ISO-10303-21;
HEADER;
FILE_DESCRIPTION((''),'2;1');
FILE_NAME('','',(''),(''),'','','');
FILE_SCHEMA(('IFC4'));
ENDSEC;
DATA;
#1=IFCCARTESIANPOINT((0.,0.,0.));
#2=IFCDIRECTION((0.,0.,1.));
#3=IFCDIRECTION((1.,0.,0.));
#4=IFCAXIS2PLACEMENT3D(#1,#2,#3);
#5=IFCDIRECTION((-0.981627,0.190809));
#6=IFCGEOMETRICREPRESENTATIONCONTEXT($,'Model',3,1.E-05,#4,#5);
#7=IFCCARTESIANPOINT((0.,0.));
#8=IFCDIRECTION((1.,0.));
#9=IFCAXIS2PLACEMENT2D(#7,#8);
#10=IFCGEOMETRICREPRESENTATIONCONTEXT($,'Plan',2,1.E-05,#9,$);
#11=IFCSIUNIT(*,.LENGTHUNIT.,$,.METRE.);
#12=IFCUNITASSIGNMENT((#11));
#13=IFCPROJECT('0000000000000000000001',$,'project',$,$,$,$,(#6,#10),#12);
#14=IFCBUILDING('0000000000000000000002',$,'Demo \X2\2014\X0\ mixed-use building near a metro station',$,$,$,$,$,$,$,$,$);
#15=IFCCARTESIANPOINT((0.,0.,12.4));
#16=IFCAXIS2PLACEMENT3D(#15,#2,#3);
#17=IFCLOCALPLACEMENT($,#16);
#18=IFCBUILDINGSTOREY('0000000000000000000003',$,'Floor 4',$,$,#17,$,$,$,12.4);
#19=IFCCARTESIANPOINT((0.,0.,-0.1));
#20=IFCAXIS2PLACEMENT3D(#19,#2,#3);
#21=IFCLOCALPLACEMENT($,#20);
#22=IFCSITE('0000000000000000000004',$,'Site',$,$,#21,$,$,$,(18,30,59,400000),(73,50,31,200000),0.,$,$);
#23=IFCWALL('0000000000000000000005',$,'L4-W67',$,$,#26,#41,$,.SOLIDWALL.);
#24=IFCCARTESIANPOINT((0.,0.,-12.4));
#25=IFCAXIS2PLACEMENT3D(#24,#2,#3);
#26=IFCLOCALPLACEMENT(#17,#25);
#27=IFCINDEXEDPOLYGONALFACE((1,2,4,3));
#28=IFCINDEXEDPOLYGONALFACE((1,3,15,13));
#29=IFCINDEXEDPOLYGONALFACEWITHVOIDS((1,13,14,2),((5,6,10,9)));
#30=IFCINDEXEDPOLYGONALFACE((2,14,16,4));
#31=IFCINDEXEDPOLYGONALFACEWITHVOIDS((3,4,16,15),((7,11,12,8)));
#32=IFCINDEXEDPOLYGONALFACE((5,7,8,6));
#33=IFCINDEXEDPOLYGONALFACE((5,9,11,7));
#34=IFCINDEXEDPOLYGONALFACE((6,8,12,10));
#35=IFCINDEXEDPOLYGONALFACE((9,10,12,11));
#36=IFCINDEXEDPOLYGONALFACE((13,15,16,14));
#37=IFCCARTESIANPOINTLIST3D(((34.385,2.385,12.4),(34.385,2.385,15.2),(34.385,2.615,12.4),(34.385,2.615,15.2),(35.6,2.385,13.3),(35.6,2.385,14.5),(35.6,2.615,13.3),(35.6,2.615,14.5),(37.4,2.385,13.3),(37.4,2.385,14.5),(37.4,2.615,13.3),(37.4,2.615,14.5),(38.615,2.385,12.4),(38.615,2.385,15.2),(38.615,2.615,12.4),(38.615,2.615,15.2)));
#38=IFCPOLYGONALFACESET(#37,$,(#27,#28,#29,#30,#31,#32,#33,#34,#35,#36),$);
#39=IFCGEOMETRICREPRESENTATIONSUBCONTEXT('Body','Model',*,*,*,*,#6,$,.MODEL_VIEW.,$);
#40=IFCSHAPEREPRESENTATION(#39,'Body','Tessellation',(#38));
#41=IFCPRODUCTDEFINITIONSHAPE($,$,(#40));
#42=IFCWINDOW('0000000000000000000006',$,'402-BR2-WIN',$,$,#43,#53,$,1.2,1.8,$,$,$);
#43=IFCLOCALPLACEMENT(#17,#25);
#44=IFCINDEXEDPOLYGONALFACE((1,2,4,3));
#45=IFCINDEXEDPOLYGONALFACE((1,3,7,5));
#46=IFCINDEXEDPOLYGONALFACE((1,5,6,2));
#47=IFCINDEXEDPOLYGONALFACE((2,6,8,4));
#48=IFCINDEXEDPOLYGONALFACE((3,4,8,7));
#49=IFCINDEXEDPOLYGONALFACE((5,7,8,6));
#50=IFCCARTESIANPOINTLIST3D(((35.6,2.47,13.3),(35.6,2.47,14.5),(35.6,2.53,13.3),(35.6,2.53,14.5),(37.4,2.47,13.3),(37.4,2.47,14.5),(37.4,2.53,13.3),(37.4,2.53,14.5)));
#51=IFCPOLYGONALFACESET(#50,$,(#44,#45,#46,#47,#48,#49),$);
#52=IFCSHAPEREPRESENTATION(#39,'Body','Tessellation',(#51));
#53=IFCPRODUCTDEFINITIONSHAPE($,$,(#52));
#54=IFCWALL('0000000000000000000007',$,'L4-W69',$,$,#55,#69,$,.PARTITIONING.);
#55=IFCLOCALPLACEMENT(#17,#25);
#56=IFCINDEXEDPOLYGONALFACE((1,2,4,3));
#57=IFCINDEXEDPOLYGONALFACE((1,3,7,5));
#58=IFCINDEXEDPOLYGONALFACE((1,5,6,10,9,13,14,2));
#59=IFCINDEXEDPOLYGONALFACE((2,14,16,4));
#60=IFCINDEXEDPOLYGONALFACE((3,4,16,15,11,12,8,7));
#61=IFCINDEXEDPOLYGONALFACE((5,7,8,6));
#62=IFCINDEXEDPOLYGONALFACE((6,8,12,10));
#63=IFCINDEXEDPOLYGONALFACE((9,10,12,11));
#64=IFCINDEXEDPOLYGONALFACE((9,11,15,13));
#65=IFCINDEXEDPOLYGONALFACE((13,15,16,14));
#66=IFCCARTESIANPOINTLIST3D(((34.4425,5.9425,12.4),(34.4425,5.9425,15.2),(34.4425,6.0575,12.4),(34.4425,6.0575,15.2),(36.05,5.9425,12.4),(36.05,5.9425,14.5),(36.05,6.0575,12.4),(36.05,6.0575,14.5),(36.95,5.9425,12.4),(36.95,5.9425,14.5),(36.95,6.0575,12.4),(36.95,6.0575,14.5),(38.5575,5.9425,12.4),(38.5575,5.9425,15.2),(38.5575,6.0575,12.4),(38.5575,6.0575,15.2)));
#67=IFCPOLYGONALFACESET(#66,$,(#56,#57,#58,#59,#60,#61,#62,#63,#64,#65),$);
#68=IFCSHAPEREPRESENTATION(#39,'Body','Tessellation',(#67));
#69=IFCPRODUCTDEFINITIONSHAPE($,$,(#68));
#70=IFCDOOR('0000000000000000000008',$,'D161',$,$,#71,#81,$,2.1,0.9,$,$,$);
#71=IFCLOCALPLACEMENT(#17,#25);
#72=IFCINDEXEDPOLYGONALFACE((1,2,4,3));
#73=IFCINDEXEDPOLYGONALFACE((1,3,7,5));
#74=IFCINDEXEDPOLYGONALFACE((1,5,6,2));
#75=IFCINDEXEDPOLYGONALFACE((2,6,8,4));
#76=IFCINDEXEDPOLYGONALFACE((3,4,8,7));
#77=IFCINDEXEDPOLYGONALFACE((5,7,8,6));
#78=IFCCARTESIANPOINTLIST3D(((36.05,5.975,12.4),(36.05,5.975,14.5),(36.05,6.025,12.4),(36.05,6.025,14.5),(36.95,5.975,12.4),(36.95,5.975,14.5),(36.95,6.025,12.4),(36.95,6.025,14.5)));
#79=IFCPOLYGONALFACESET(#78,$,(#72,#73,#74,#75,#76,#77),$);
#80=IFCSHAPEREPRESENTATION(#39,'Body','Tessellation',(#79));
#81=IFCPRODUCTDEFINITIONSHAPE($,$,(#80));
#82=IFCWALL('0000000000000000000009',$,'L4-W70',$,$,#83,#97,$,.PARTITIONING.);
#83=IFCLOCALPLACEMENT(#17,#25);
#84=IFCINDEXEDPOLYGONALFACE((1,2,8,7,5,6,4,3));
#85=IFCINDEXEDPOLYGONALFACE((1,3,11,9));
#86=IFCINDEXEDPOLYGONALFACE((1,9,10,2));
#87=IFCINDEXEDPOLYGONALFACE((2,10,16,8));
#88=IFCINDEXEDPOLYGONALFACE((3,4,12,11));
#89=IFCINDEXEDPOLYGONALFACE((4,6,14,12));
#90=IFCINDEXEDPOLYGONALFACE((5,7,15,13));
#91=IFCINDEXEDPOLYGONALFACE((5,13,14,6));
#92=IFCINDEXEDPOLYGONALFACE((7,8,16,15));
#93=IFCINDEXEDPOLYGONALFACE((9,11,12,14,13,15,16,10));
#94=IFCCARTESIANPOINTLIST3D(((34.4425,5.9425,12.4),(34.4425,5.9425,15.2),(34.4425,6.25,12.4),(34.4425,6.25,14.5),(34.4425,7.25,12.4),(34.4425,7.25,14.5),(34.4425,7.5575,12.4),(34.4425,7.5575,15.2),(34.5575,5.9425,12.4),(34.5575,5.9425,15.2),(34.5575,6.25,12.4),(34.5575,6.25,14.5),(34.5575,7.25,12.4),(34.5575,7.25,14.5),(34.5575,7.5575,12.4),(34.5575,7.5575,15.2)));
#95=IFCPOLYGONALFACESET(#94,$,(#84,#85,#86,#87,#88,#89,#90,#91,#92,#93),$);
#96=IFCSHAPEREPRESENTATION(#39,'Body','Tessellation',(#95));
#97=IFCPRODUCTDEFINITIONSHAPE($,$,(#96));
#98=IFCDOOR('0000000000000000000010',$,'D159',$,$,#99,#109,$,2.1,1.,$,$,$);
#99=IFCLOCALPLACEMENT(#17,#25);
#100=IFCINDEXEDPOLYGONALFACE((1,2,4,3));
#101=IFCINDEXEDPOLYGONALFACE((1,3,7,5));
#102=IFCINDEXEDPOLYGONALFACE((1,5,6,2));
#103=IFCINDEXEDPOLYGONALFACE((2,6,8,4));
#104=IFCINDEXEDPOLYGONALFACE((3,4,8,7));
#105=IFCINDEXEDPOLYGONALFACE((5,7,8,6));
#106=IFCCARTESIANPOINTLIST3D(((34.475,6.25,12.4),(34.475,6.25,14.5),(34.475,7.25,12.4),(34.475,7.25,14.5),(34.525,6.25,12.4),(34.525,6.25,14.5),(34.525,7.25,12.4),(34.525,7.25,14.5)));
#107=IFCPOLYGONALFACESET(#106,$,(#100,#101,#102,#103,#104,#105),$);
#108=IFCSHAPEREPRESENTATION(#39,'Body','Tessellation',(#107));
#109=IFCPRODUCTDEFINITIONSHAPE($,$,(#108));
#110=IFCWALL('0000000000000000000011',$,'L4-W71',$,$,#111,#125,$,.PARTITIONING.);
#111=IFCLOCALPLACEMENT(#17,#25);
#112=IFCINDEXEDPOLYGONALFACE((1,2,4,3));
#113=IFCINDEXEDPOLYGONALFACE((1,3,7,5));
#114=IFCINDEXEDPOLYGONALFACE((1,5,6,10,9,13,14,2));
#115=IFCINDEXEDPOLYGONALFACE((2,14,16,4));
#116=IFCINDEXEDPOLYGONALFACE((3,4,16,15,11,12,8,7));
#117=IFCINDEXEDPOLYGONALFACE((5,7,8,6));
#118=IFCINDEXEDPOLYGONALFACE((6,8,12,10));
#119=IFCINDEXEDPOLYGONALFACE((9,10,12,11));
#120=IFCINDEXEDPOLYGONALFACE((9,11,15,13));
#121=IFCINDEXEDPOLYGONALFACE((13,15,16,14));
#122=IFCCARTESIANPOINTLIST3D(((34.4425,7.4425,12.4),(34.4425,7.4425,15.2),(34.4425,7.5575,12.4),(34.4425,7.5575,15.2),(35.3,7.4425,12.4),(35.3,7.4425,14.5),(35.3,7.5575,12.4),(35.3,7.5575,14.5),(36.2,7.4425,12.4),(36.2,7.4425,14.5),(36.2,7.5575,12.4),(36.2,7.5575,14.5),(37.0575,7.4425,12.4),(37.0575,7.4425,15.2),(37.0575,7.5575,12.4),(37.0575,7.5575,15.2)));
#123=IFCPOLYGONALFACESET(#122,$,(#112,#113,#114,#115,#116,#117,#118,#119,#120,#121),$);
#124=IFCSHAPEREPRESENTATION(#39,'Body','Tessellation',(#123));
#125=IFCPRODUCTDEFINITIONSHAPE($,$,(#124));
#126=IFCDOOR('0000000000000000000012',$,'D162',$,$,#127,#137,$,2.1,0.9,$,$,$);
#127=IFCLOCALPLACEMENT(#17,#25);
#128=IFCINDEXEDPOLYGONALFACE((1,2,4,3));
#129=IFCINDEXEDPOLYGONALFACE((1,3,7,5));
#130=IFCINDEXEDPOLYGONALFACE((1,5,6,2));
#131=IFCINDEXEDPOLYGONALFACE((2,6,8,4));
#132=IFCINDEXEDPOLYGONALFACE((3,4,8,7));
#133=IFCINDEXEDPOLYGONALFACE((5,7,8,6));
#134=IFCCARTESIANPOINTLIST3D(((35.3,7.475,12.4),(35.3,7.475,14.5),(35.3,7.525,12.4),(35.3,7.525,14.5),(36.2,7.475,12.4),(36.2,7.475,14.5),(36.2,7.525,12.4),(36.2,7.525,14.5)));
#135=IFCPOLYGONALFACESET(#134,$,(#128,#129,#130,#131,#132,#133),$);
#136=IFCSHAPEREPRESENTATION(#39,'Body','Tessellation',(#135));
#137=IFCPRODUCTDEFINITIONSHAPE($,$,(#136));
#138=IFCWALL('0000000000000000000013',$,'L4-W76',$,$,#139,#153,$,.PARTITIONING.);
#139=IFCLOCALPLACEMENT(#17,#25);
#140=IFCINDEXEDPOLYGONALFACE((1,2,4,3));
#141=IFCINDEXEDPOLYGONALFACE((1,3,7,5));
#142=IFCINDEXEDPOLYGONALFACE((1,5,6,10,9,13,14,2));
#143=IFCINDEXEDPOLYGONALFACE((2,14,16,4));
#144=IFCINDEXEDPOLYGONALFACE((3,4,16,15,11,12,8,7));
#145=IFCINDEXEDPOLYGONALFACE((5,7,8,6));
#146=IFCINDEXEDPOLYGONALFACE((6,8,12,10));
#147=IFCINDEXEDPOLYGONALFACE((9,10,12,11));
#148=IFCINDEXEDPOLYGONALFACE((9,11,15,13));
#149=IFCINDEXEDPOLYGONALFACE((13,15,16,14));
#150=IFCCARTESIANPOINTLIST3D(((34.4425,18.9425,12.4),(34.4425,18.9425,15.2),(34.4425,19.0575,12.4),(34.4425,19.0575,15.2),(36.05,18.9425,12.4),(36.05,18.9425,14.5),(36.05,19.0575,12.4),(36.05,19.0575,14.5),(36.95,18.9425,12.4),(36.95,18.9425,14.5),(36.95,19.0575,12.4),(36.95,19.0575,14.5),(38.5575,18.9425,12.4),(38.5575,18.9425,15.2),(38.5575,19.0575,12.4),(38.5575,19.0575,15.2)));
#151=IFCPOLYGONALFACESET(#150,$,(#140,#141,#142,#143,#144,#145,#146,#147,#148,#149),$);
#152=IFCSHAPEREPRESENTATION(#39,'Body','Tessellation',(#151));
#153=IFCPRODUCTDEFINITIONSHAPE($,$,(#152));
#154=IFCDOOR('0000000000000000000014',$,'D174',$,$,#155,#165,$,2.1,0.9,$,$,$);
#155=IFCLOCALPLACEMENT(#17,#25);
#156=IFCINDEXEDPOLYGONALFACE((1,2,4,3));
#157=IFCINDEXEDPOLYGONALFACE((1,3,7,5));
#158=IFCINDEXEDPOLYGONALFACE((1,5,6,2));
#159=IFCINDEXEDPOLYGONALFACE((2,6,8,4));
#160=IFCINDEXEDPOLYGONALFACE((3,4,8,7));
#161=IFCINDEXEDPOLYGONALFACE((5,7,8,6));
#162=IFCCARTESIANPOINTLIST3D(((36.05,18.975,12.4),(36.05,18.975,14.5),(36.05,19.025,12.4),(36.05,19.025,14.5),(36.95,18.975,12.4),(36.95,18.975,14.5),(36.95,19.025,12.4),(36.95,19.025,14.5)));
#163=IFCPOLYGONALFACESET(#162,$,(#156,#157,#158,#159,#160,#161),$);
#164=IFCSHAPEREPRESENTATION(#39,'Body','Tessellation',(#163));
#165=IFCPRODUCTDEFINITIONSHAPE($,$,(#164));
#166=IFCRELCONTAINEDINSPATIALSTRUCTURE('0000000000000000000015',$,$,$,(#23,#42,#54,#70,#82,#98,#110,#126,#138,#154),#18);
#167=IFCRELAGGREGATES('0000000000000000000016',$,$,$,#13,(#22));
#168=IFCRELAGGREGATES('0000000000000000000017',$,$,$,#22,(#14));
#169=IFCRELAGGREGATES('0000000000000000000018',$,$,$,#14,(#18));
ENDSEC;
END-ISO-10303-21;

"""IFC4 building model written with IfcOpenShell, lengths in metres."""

from ifc_helpers import new_model, si_unit, direction, frame, origin_with_axes, origin_2d_with_axis, place, context, subcontext, project, spatial, line, indexed_curve, outline, extrude, element, fill, save


model = new_model("IFC4")

# Units and contexts
model_context = context("Model", 3, precision=1e-05, world=origin_with_axes(), true_north=direction((-0.981627, 0.190809)))
plan_context = context("Plan", 2, precision=1e-05, world=origin_2d_with_axis())
body_context = subcontext(model_context, "Body", "Model", "MODEL_VIEW")
ifc_project = project(units=[si_unit("LENGTHUNIT", "METRE")], contexts=[model_context, plan_context])

# Site, building, storey
site_placement = place(None, frame((0.0, 0.0, -0.1), z_axis=(0.0, 0.0, 1.0), x_axis=(1.0, 0.0, 0.0)))
site = spatial("IfcSite", under=ifc_project, at=site_placement, Name="Site", RefLatitude=(18, 30, 59, 400000), RefLongitude=(73, 50, 31, 200000), RefElevation=0.0)
building = spatial("IfcBuilding", under=site, Name="Demo — mixed-use building near a metro station")
storey_placement = place(None, frame((0.0, 0.0, 12.4), z_axis=(0.0, 0.0, 1.0), x_axis=(1.0, 0.0, 0.0)))
storey = spatial("IfcBuildingStorey", under=building, at=storey_placement, Name="Floor 4", Elevation=12.4)

# Wall, opening, window
wall_1_placement = place(storey_placement, frame((0.0, 0.0, -12.4), z_axis=(0.0, 0.0, 1.0), x_axis=(1.0, 0.0, 0.0)))
wall_1 = element("IfcWall", 1, at=wall_1_placement, inside=storey, Name="L4-W67", PredefinedType="SOLIDWALL", context=body_context, shape_type="SweptSolid", body=[
    extrude(outline(indexed_curve([(34.385, 2.615), (38.615, 2.615), (38.615, 2.385), (34.385, 2.385)], segments=[line(1, 2, 3, 4, 1)])), frame((0.0, 0.0, 12.4), z_axis=(0.0, 0.0, 1.0), x_axis=(1.0, 0.0, 0.0)), (0.0, 0.0, 1.0), 2.8),
])
opening_1_placement = place(wall_1_placement, origin_with_axes())
opening_1 = element("IfcOpeningElement", 2, at=opening_1_placement, cuts=wall_1, context=body_context, shape_type="SweptSolid", body=[
    extrude(outline(indexed_curve([(35.6, 2.665), (37.4, 2.665), (37.4, 2.335), (35.6, 2.335)], segments=[line(1, 2, 3, 4, 1)])), frame((0.0, 0.0, 13.3), z_axis=(0.0, 0.0, 1.0), x_axis=(1.0, 0.0, 0.0)), (0.0, 0.0, 1.0), 1.2),
])
window_placement = place(storey_placement, frame((0.0, 0.0, -12.4), z_axis=(0.0, 0.0, 1.0), x_axis=(1.0, 0.0, 0.0)))
window = element("IfcWindow", 3, at=window_placement, inside=storey, Name="402-BR2-WIN", OverallHeight=1.2, OverallWidth=1.8, context=body_context, shape_type="SweptSolid", body=[
    extrude(outline(indexed_curve([(35.6, 2.53), (37.4, 2.53), (37.4, 2.47), (35.6, 2.47)], segments=[line(1, 2, 3, 4, 1)])), frame((0.0, 0.0, 13.3), z_axis=(0.0, 0.0, 1.0), x_axis=(1.0, 0.0, 0.0)), (0.0, 0.0, 1.0), 1.2),
])
fill(opening_1, window)

# Walls, openings, doors
wall_2_placement = place(storey_placement, frame((0.0, 0.0, -12.4), z_axis=(0.0, 0.0, 1.0), x_axis=(1.0, 0.0, 0.0)))
wall_2 = element("IfcWall", 4, at=wall_2_placement, inside=storey, Name="L4-W69", PredefinedType="PARTITIONING", context=body_context, shape_type="SweptSolid", body=[
    extrude(outline(indexed_curve([(38.5575, 5.9425), (34.4425, 5.9425), (34.4425, 6.0575), (38.5575, 6.0575)], segments=[line(1, 2, 3, 4, 1)])), frame((0.0, 0.0, 12.4), z_axis=(0.0, 0.0, 1.0), x_axis=(1.0, 0.0, 0.0)), (0.0, 0.0, 1.0), 2.8),
])
opening_2_placement = place(wall_2_placement, origin_with_axes())
opening_2 = element("IfcOpeningElement", 5, at=opening_2_placement, cuts=wall_2, context=body_context, shape_type="SweptSolid", body=[
    extrude(outline(indexed_curve([(36.95, 5.8925), (36.05, 5.8925), (36.05, 6.1075), (36.95, 6.1075)], segments=[line(1, 2, 3, 4, 1)])), frame((0.0, 0.0, 12.4), z_axis=(0.0, 0.0, 1.0), x_axis=(1.0, 0.0, 0.0)), (0.0, 0.0, 1.0), 2.1),
])
door_1_placement = place(storey_placement, frame((0.0, 0.0, -12.4), z_axis=(0.0, 0.0, 1.0), x_axis=(1.0, 0.0, 0.0)))
door_1 = element("IfcDoor", 6, at=door_1_placement, inside=storey, Name="D161", OverallHeight=2.1, OverallWidth=0.9, context=body_context, shape_type="SweptSolid", body=[
    extrude(outline(indexed_curve([(36.95, 5.975), (36.05, 5.975), (36.05, 6.025), (36.95, 6.025)], segments=[line(1, 2, 3, 4, 1)])), frame((0.0, 0.0, 12.4), z_axis=(0.0, 0.0, 1.0), x_axis=(1.0, 0.0, 0.0)), (0.0, 0.0, 1.0), 2.1),
])
fill(opening_2, door_1)
wall_3_placement = place(storey_placement, frame((0.0, 0.0, -12.4), z_axis=(0.0, 0.0, 1.0), x_axis=(1.0, 0.0, 0.0)))
wall_3 = element("IfcWall", 7, at=wall_3_placement, inside=storey, Name="L4-W70", PredefinedType="PARTITIONING", context=body_context, shape_type="SweptSolid", body=[
    extrude(outline(indexed_curve([(34.4425, 5.9425), (34.4425, 7.5575), (34.5575, 7.5575), (34.5575, 5.9425)], segments=[line(1, 2, 3, 4, 1)])), frame((0.0, 0.0, 12.4), z_axis=(0.0, 0.0, 1.0), x_axis=(1.0, 0.0, 0.0)), (0.0, 0.0, 1.0), 2.8),
])
opening_3_placement = place(wall_3_placement, origin_with_axes())
opening_3 = element("IfcOpeningElement", 8, at=opening_3_placement, cuts=wall_3, context=body_context, shape_type="SweptSolid", body=[
    extrude(outline(indexed_curve([(34.3925, 6.25), (34.3925, 7.25), (34.6075, 7.25), (34.6075, 6.25)], segments=[line(1, 2, 3, 4, 1)])), frame((0.0, 0.0, 12.4), z_axis=(0.0, 0.0, 1.0), x_axis=(1.0, 0.0, 0.0)), (0.0, 0.0, 1.0), 2.1),
])
door_2_placement = place(storey_placement, frame((0.0, 0.0, -12.4), z_axis=(0.0, 0.0, 1.0), x_axis=(1.0, 0.0, 0.0)))
door_2 = element("IfcDoor", 9, at=door_2_placement, inside=storey, Name="D159", OverallHeight=2.1, OverallWidth=1.0, context=body_context, shape_type="SweptSolid", body=[
    extrude(outline(indexed_curve([(34.475, 6.25), (34.475, 7.25), (34.525, 7.25), (34.525, 6.25)], segments=[line(1, 2, 3, 4, 1)])), frame((0.0, 0.0, 12.4), z_axis=(0.0, 0.0, 1.0), x_axis=(1.0, 0.0, 0.0)), (0.0, 0.0, 1.0), 2.1),
])
fill(opening_3, door_2)
wall_4_placement = place(storey_placement, frame((0.0, 0.0, -12.4), z_axis=(0.0, 0.0, 1.0), x_axis=(1.0, 0.0, 0.0)))
wall_4 = element("IfcWall", 10, at=wall_4_placement, inside=storey, Name="L4-W71", PredefinedType="PARTITIONING", context=body_context, shape_type="SweptSolid", body=[
    extrude(outline(indexed_curve([(37.0575, 7.4425), (34.4425, 7.4425), (34.4425, 7.5575), (37.0575, 7.5575)], segments=[line(1, 2, 3, 4, 1)])), frame((0.0, 0.0, 12.4), z_axis=(0.0, 0.0, 1.0), x_axis=(1.0, 0.0, 0.0)), (0.0, 0.0, 1.0), 2.8),
])
opening_4_placement = place(wall_4_placement, origin_with_axes())
opening_4 = element("IfcOpeningElement", 11, at=opening_4_placement, cuts=wall_4, context=body_context, shape_type="SweptSolid", body=[
    extrude(outline(indexed_curve([(36.2, 7.3925), (35.3, 7.3925), (35.3, 7.6075), (36.2, 7.6075)], segments=[line(1, 2, 3, 4, 1)])), frame((0.0, 0.0, 12.4), z_axis=(0.0, 0.0, 1.0), x_axis=(1.0, 0.0, 0.0)), (0.0, 0.0, 1.0), 2.1),
])
door_3_placement = place(storey_placement, frame((0.0, 0.0, -12.4), z_axis=(0.0, 0.0, 1.0), x_axis=(1.0, 0.0, 0.0)))
door_3 = element("IfcDoor", 12, at=door_3_placement, inside=storey, Name="D162", OverallHeight=2.1, OverallWidth=0.9, context=body_context, shape_type="SweptSolid", body=[
    extrude(outline(indexed_curve([(36.2, 7.475), (35.3, 7.475), (35.3, 7.525), (36.2, 7.525)], segments=[line(1, 2, 3, 4, 1)])), frame((0.0, 0.0, 12.4), z_axis=(0.0, 0.0, 1.0), x_axis=(1.0, 0.0, 0.0)), (0.0, 0.0, 1.0), 2.1),
])
fill(opening_4, door_3)

# Wall, opening, door
wall_5_placement = place(storey_placement, frame((0.0, 0.0, -12.4), z_axis=(0.0, 0.0, 1.0), x_axis=(1.0, 0.0, 0.0)))
wall_5 = element("IfcWall", 13, at=wall_5_placement, inside=storey, Name="L4-W76", PredefinedType="PARTITIONING", context=body_context, shape_type="SweptSolid", body=[
    extrude(outline(indexed_curve([(38.5575, 18.9425), (34.4425, 18.9425), (34.4425, 19.0575), (38.5575, 19.0575)], segments=[line(1, 2, 3, 4, 1)])), frame((0.0, 0.0, 12.4), z_axis=(0.0, 0.0, 1.0), x_axis=(1.0, 0.0, 0.0)), (0.0, 0.0, 1.0), 2.8),
])
opening_5_placement = place(wall_5_placement, origin_with_axes())
opening_5 = element("IfcOpeningElement", 14, at=opening_5_placement, cuts=wall_5, context=body_context, shape_type="SweptSolid", body=[
    extrude(outline(indexed_curve([(36.95, 18.8925), (36.05, 18.8925), (36.05, 19.1075), (36.95, 19.1075)], segments=[line(1, 2, 3, 4, 1)])), frame((0.0, 0.0, 12.4), z_axis=(0.0, 0.0, 1.0), x_axis=(1.0, 0.0, 0.0)), (0.0, 0.0, 1.0), 2.1),
])
door_4_placement = place(storey_placement, frame((0.0, 0.0, -12.4), z_axis=(0.0, 0.0, 1.0), x_axis=(1.0, 0.0, 0.0)))
door_4 = element("IfcDoor", 15, at=door_4_placement, inside=storey, Name="D174", OverallHeight=2.1, OverallWidth=0.9, context=body_context, shape_type="SweptSolid", body=[
    extrude(outline(indexed_curve([(36.95, 18.975), (36.05, 18.975), (36.05, 19.025), (36.95, 19.025)], segments=[line(1, 2, 3, 4, 1)])), frame((0.0, 0.0, 12.4), z_axis=(0.0, 0.0, 1.0), x_axis=(1.0, 0.0, 0.0)), (0.0, 0.0, 1.0), 2.1),
])
fill(opening_5, door_4)

save(model, "model.ifc")
